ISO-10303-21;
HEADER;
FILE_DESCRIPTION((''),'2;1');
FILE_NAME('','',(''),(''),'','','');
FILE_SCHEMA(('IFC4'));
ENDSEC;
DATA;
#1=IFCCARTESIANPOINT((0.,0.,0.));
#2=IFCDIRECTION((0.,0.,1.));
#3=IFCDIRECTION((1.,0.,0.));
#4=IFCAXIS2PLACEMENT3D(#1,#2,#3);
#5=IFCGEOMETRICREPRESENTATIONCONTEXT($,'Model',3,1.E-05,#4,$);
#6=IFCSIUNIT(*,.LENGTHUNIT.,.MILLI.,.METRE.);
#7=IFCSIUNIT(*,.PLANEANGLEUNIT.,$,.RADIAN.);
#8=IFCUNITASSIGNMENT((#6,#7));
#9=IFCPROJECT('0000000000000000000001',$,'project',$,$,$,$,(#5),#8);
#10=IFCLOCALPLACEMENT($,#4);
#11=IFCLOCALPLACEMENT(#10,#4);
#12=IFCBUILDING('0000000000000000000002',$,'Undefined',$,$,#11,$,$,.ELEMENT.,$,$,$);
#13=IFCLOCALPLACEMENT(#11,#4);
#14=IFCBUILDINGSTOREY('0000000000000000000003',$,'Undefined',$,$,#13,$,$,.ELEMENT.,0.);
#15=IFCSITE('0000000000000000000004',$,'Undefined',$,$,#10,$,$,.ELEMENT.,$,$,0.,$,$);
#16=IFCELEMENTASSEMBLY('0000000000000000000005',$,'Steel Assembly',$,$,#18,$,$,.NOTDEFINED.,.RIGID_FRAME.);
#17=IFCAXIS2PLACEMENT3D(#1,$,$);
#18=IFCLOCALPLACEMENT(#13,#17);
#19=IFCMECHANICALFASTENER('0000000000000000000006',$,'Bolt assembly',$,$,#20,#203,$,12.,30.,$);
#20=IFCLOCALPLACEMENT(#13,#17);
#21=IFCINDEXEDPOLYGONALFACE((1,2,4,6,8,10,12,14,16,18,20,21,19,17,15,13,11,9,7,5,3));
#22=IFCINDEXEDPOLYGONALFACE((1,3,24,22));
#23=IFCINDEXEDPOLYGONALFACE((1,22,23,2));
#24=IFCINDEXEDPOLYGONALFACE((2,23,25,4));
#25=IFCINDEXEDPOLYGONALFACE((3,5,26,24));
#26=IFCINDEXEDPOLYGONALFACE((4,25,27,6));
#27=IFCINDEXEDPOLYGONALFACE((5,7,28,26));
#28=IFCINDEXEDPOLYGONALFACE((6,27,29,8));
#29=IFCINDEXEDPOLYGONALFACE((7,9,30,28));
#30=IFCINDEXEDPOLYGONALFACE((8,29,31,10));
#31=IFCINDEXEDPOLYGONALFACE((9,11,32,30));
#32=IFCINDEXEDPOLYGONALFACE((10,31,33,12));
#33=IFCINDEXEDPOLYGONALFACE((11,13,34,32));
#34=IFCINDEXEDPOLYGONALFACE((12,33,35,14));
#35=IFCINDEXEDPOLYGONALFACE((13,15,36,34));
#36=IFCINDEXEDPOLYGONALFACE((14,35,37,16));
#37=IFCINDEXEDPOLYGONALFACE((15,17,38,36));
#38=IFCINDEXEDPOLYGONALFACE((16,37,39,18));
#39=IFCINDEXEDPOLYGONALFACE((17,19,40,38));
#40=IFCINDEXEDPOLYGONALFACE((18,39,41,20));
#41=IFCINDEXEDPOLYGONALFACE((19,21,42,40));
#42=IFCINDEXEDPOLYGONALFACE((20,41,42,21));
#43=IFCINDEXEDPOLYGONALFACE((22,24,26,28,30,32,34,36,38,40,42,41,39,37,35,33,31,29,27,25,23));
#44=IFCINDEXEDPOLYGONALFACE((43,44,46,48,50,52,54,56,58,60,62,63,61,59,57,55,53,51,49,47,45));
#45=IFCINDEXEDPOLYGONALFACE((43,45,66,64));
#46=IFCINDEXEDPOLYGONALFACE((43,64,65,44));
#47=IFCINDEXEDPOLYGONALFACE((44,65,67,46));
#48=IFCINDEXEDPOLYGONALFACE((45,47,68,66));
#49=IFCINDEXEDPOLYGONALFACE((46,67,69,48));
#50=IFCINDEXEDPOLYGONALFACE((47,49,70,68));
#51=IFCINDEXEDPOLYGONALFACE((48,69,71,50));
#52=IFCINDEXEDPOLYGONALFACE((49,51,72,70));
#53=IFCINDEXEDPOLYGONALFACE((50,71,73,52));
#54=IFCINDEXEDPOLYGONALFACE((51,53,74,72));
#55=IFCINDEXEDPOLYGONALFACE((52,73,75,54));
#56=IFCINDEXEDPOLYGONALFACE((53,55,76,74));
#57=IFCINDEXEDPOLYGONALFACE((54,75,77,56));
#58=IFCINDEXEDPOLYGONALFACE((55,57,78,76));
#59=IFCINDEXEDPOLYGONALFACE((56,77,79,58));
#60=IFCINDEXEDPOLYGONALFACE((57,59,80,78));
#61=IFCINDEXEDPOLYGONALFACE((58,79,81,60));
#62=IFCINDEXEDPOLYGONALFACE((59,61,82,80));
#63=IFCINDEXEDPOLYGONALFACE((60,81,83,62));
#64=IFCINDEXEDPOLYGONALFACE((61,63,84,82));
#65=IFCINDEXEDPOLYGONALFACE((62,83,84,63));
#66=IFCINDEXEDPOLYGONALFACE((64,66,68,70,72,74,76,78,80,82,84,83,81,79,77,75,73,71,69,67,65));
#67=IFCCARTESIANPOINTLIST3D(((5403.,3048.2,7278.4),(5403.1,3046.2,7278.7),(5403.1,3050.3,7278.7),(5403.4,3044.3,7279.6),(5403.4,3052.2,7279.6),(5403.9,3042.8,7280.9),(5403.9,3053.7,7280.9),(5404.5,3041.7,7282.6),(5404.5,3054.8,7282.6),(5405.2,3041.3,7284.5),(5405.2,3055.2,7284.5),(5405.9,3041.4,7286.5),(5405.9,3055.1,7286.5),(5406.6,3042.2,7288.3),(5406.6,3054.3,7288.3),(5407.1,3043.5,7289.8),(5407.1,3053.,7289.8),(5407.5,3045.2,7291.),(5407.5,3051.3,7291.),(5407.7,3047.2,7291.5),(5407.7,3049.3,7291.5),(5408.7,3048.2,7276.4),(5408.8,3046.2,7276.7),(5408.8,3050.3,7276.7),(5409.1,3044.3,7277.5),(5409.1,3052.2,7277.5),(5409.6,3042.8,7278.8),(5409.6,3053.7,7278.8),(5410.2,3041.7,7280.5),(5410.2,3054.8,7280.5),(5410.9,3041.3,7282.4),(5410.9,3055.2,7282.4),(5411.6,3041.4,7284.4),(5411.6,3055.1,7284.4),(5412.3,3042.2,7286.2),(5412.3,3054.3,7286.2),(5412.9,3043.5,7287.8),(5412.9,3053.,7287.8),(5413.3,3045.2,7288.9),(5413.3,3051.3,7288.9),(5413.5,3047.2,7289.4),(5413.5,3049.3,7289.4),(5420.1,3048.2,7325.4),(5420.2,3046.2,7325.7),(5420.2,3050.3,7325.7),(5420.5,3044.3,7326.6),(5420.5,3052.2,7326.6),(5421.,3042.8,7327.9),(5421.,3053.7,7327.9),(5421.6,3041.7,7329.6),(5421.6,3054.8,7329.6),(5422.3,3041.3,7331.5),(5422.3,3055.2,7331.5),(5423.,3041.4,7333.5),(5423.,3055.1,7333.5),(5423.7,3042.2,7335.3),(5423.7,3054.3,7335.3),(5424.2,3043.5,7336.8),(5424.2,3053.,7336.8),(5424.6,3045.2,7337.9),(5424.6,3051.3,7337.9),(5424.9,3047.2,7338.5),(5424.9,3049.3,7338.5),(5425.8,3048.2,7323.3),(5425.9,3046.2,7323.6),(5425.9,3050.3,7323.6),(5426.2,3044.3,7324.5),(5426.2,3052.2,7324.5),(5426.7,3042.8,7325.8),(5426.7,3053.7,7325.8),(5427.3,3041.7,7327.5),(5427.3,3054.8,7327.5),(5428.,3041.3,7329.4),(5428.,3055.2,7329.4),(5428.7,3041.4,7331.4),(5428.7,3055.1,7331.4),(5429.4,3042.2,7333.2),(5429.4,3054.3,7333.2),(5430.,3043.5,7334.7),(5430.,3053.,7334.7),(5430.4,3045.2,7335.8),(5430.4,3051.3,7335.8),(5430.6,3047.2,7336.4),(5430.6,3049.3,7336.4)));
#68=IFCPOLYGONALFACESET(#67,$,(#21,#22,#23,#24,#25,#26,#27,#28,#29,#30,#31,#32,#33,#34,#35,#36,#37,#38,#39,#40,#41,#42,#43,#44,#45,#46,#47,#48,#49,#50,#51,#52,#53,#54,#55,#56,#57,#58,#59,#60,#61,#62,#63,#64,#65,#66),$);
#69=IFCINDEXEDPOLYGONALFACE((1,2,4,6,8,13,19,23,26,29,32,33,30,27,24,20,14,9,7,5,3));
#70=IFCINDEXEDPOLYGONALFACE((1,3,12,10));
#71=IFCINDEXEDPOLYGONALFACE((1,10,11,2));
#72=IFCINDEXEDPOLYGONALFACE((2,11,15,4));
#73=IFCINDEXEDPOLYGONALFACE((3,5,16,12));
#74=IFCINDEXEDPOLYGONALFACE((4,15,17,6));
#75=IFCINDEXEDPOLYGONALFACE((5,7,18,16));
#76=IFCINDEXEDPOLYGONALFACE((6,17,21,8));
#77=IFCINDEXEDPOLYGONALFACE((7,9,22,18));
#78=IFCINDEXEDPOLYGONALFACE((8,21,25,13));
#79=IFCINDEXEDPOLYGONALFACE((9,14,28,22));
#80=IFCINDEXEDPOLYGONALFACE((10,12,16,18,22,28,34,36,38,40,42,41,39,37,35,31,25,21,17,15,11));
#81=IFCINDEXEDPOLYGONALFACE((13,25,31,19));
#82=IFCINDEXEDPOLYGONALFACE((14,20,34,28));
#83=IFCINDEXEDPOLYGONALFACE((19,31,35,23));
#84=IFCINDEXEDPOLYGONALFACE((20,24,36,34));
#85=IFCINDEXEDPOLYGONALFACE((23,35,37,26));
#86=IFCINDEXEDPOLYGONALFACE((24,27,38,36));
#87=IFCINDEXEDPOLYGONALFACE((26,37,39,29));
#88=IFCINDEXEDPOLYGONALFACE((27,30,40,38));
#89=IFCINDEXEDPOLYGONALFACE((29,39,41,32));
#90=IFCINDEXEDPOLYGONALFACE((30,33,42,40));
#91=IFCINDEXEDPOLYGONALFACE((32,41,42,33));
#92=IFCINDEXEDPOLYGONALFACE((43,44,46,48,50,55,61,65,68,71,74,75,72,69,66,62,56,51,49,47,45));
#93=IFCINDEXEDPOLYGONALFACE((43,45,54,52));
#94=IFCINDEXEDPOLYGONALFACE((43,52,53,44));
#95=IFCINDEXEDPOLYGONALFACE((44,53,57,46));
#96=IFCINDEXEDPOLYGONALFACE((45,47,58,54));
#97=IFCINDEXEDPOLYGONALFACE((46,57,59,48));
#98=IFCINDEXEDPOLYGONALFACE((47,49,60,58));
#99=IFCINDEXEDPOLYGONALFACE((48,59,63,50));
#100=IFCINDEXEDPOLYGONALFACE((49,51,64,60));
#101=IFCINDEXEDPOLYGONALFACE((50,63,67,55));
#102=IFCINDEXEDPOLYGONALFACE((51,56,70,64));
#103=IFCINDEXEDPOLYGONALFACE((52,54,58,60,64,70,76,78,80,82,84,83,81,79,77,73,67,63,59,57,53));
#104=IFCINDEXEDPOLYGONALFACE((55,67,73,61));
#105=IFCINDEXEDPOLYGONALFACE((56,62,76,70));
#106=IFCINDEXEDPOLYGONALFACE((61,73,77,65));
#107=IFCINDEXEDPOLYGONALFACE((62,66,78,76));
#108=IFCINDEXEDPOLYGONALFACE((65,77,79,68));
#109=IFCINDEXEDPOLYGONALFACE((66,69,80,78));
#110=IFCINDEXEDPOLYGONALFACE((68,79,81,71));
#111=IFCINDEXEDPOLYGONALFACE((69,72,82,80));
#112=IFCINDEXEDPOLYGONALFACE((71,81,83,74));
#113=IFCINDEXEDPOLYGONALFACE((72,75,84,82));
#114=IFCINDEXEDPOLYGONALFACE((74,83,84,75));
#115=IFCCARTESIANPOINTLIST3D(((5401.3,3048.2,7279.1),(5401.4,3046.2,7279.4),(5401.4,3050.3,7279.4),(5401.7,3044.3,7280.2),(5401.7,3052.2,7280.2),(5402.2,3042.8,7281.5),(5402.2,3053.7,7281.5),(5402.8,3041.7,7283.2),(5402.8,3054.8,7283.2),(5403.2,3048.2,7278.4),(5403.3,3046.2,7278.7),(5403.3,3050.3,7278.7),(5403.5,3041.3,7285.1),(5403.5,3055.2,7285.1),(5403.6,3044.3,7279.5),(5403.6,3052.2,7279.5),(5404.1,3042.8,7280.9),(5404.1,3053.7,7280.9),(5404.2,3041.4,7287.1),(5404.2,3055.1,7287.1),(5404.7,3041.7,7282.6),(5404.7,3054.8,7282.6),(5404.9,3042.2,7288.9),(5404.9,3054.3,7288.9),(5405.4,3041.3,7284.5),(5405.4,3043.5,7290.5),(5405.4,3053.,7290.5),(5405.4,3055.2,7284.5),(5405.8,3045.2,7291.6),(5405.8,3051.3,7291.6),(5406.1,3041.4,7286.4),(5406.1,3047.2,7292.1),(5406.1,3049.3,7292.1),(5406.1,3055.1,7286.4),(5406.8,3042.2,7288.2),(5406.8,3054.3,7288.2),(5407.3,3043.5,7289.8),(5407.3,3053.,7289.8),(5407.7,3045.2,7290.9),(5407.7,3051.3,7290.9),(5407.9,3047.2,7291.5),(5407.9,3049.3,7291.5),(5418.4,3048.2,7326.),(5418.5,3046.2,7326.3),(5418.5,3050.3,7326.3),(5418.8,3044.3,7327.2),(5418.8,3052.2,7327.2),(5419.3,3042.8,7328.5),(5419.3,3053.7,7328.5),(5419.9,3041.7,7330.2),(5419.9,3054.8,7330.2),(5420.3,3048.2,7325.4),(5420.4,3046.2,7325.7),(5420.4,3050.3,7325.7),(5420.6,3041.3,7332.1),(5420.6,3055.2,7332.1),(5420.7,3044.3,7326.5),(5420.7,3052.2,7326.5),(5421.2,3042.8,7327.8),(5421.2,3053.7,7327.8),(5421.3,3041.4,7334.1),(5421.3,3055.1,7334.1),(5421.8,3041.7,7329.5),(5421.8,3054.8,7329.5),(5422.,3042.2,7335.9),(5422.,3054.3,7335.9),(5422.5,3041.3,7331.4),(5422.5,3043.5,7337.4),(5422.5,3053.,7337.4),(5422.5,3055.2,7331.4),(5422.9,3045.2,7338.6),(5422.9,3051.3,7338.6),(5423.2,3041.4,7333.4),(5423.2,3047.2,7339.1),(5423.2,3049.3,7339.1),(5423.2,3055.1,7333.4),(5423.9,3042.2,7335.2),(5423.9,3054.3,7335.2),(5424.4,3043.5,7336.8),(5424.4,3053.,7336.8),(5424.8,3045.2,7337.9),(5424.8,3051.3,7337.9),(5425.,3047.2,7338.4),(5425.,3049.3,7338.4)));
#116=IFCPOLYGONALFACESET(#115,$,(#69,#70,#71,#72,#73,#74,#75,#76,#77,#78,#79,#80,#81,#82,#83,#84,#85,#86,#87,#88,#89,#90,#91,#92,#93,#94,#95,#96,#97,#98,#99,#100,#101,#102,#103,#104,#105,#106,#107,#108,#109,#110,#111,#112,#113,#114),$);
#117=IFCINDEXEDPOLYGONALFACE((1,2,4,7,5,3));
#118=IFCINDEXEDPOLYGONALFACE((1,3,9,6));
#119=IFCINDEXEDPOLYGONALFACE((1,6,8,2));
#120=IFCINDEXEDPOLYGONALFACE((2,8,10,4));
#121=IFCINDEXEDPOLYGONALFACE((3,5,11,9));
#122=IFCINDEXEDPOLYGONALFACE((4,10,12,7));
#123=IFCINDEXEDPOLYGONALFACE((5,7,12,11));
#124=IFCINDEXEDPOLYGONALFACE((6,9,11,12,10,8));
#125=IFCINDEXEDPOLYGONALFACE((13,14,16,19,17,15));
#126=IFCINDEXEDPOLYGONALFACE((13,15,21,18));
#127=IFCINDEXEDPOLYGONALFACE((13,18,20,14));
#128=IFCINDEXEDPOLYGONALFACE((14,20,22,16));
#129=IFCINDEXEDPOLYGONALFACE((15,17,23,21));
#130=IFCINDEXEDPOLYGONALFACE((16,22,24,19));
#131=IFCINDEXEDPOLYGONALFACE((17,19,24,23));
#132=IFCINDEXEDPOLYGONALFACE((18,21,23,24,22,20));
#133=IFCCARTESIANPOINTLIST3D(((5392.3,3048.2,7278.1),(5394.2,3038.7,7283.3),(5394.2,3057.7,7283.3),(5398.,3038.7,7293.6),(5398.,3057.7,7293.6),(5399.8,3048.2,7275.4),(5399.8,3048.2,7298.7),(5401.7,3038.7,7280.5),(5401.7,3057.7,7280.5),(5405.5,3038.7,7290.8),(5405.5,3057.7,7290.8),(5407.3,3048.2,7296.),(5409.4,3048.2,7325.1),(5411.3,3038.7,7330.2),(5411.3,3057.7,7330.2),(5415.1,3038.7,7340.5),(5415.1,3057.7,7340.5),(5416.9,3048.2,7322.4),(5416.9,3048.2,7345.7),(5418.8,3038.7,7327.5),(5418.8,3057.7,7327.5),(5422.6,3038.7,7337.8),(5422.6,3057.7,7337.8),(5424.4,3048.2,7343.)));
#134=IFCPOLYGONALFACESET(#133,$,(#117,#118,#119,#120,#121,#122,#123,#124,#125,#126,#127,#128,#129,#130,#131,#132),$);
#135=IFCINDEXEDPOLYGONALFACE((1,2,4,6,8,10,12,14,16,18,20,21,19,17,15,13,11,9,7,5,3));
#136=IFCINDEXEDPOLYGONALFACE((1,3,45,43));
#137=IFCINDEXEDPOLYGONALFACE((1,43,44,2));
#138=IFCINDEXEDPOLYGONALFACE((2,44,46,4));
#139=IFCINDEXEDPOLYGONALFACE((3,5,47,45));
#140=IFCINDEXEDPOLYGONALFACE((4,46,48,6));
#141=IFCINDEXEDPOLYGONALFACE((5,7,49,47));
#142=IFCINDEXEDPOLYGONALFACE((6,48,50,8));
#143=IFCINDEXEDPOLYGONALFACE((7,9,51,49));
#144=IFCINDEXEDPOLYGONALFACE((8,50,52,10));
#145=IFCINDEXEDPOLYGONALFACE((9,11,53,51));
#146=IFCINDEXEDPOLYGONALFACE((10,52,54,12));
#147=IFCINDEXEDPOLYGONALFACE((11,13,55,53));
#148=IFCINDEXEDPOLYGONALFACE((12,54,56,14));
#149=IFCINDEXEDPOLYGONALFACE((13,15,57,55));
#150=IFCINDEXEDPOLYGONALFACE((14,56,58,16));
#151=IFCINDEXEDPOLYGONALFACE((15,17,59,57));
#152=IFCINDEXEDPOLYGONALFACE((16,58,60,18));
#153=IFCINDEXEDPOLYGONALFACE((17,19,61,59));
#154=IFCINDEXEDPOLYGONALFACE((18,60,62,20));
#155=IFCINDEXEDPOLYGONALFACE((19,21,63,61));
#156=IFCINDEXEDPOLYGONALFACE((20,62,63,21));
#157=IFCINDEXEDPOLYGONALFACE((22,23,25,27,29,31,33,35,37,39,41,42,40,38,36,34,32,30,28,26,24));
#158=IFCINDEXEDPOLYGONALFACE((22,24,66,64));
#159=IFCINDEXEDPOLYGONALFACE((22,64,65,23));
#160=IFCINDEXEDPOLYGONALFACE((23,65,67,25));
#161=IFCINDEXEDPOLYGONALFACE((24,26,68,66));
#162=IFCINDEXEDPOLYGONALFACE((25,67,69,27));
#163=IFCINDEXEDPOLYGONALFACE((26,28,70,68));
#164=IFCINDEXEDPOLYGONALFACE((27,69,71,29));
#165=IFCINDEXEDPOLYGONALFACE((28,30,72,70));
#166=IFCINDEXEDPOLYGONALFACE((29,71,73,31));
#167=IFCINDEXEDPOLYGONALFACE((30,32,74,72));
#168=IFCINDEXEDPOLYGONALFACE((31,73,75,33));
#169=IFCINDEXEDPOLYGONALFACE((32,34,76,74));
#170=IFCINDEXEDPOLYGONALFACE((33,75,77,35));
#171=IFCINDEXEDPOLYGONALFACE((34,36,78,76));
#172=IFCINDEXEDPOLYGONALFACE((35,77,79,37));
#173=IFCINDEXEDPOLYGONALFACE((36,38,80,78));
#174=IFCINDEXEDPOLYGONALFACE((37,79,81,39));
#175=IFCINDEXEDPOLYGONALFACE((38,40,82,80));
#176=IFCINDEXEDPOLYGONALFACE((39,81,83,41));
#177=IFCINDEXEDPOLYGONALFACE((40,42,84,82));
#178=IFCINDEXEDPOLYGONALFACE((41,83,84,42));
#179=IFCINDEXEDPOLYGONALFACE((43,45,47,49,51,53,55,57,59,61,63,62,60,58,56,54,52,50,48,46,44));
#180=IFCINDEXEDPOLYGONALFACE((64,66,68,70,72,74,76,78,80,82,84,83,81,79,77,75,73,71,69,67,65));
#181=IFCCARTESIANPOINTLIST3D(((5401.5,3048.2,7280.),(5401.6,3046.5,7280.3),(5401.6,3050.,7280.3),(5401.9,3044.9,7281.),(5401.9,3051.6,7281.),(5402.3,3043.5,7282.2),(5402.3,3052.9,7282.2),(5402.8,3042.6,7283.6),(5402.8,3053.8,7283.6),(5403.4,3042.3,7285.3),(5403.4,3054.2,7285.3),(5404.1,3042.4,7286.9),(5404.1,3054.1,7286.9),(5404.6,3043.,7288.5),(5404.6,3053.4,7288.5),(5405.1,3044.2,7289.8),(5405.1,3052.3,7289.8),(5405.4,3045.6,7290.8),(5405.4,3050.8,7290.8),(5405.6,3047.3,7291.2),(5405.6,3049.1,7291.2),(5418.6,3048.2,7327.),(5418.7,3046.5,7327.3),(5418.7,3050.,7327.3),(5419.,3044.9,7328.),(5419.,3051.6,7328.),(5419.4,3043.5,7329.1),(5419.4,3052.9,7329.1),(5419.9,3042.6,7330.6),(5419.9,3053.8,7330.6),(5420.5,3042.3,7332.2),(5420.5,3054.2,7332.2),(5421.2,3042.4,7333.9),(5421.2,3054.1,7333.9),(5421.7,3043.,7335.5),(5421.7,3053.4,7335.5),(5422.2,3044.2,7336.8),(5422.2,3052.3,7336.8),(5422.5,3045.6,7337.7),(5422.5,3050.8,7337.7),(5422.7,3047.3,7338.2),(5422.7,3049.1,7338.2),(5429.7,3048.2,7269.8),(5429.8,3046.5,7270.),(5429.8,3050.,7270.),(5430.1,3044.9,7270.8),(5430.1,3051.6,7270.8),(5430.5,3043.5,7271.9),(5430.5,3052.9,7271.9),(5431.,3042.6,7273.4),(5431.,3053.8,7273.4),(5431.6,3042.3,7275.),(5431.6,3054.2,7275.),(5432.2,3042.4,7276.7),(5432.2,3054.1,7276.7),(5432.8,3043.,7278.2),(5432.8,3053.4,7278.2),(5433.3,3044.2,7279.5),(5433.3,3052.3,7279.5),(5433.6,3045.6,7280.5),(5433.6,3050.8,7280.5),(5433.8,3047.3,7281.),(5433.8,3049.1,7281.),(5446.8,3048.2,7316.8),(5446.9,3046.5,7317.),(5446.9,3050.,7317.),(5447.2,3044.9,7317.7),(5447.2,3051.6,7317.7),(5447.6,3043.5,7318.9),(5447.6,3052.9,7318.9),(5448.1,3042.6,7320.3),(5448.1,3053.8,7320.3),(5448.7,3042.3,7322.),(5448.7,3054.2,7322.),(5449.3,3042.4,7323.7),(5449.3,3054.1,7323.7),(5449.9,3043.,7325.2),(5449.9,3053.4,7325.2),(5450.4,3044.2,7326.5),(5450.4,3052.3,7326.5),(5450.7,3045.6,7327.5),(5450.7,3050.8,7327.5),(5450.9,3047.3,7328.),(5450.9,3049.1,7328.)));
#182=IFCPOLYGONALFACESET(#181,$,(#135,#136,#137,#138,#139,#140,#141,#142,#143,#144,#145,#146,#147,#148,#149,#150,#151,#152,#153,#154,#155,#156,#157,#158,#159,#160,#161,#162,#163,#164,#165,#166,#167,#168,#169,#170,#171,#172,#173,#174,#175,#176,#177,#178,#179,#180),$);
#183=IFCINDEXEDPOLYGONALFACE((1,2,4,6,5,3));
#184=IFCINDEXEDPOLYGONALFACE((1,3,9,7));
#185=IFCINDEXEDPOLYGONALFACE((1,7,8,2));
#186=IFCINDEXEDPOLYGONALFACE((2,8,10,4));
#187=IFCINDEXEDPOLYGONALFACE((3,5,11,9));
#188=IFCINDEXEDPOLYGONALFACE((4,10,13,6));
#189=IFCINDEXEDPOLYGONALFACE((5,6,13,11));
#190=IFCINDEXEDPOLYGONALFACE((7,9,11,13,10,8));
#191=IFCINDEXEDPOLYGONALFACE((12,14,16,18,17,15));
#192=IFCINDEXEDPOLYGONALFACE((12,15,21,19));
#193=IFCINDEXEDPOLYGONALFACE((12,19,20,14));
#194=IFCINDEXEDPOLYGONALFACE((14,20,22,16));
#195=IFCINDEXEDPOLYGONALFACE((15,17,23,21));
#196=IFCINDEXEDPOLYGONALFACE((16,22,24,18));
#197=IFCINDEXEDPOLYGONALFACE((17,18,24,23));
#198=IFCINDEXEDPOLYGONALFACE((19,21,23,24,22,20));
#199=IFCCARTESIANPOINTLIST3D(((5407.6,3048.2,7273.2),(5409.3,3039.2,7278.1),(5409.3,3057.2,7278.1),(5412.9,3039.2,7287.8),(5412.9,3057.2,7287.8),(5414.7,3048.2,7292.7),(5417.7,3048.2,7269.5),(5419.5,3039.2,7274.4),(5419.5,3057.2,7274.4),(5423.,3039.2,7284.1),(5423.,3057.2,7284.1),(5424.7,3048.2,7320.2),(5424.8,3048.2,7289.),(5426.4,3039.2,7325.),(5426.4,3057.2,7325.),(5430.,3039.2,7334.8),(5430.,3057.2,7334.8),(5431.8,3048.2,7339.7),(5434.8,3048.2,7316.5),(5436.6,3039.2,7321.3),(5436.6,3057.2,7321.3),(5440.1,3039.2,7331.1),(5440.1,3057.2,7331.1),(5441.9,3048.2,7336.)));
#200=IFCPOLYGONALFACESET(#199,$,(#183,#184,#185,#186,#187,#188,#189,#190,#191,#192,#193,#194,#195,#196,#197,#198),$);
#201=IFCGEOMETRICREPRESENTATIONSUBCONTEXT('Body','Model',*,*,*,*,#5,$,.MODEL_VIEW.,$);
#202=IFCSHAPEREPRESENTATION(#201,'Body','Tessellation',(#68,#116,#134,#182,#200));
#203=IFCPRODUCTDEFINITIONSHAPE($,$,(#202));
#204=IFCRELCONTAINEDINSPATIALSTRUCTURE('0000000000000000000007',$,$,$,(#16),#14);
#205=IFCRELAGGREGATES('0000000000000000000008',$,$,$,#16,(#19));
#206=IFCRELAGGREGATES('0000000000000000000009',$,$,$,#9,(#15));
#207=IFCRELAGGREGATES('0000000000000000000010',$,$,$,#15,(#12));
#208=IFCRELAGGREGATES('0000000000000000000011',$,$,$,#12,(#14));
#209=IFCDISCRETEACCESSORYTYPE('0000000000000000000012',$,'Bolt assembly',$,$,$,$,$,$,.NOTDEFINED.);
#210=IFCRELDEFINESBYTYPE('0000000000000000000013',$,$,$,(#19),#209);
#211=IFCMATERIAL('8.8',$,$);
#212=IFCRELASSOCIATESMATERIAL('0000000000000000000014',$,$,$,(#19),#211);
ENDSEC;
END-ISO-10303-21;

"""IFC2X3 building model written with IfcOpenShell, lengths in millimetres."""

from ifc_helpers import new_model, si_unit, frame, origin_with_axes, origin_2d_with_axis, place, context, subcontext, project, spatial, polyline, circle, outline, extrude, source, transform, mapped, material, type_object, element, aggregate, save


model = new_model("IFC2X3")

# Units and contexts
model_context = context("Model", 3, precision=1e-05, world=origin_with_axes())
body_context = subcontext(model_context, "Body", "Model", "MODEL_VIEW")
ifc_project = project(units=[si_unit("LENGTHUNIT", "METRE", prefix="MILLI"), si_unit("PLANEANGLEUNIT", "RADIAN")], contexts=[model_context])

# Site, building, storey
site_placement = place(None, origin_with_axes())
site = spatial("IfcSite", under=ifc_project, at=site_placement, Name="Undefined", CompositionType="ELEMENT", RefElevation=0.0)
building_placement = place(site_placement, origin_with_axes())
building = spatial("IfcBuilding", under=site, at=building_placement, Name="Undefined", CompositionType="ELEMENT")
storey_placement = place(building_placement, origin_with_axes())
storey = spatial("IfcBuildingStorey", under=building, at=storey_placement, Name="Undefined", CompositionType="ELEMENT", Elevation=0.0)

# Shared definitions
ifc_material_1 = material(Name="8.8")
discrete_accessory_type_1 = type_object("IfcDiscreteAccessoryType", Name="Bolt assembly")
shared_shape_1 = source(origin_with_axes(), body_context, "Body", "SweptSolid", [
    extrude(circle(Radius=7.0, at=origin_2d_with_axis()), frame((0.0, -6.1, 0.0), z_axis=(0.0, 1.0, 0.0), x_axis=(1.0, 0.0, 0.0)), (0.0, 0.0, 1.0), 6.1),
    extrude(circle(Radius=7.0, at=origin_2d_with_axis()), frame((0.0, -7.9, 0.0), z_axis=(0.0, 1.0, 0.0), x_axis=(1.0, 0.0, 0.0)), (0.0, 0.0, 1.0), 2.0),
    extrude(outline(polyline([(11.0, 0.0), (5.5, 9.5), (-5.5, 9.5), (-11.0, 0.0), (-5.5, -9.5), (5.5, -9.5), (11.0, 0.0)])), frame((0.0, -16.0, 0.0), z_axis=(0.0, 1.0, 0.0), x_axis=(1.0, 0.0, 0.0)), (0.0, 0.0, 1.0), 8.0),
    extrude(circle(Radius=6.0, at=origin_2d_with_axis()), frame((0.0, -8.0, 0.0), z_axis=(0.0, 1.0, 0.0), x_axis=(1.0, 0.0, 0.0)), (0.0, 0.0, 1.0), 30.0),
    extrude(outline(polyline([(10.4, 0.0), (5.2, 9.0), (-5.2, 9.0), (-10.4, 0.0), (-5.2, -9.0), (5.2, -9.0), (10.4, 0.0)])), frame((0.0, 0.0, 0.0), z_axis=(0.0, 1.0, 0.0), x_axis=(1.0, 0.0, 0.0)), (0.0, 0.0, 1.0), 10.8),
])

# Element assembly, mechanical fastener
assembly_1_placement = place(storey_placement, origin_with_axes())
assembly_1 = element("IfcElementAssembly", 1, at=assembly_1_placement, inside=storey, Name="Steel Assembly", AssemblyPlace="NOTDEFINED", PredefinedType="RIGID_FRAME")
mechanical_fastener_1_placement = place(assembly_1_placement, frame((5428.2, 3048.2, 7329.9), z_axis=(0.0, -1.0, 0.0), x_axis=(-0.34202, 0.0, -0.939693)))
mechanical_fastener_1 = element("IfcMechanicalFastener", 2, at=mechanical_fastener_1_placement, type_object=discrete_accessory_type_1, material=ifc_material_1, Name="Bolt assembly", NominalDiameter=12.0, NominalLength=30.0, context=body_context, shape_type="MappedRepresentation", body=[
    mapped(shared_shape_1, transform((0.0, 0.0, 0.0))),
    mapped(shared_shape_1, transform((50.0, 0.0, 0.0))),
])
aggregate(assembly_1, [mechanical_fastener_1])

save(model, "model.ifc")
